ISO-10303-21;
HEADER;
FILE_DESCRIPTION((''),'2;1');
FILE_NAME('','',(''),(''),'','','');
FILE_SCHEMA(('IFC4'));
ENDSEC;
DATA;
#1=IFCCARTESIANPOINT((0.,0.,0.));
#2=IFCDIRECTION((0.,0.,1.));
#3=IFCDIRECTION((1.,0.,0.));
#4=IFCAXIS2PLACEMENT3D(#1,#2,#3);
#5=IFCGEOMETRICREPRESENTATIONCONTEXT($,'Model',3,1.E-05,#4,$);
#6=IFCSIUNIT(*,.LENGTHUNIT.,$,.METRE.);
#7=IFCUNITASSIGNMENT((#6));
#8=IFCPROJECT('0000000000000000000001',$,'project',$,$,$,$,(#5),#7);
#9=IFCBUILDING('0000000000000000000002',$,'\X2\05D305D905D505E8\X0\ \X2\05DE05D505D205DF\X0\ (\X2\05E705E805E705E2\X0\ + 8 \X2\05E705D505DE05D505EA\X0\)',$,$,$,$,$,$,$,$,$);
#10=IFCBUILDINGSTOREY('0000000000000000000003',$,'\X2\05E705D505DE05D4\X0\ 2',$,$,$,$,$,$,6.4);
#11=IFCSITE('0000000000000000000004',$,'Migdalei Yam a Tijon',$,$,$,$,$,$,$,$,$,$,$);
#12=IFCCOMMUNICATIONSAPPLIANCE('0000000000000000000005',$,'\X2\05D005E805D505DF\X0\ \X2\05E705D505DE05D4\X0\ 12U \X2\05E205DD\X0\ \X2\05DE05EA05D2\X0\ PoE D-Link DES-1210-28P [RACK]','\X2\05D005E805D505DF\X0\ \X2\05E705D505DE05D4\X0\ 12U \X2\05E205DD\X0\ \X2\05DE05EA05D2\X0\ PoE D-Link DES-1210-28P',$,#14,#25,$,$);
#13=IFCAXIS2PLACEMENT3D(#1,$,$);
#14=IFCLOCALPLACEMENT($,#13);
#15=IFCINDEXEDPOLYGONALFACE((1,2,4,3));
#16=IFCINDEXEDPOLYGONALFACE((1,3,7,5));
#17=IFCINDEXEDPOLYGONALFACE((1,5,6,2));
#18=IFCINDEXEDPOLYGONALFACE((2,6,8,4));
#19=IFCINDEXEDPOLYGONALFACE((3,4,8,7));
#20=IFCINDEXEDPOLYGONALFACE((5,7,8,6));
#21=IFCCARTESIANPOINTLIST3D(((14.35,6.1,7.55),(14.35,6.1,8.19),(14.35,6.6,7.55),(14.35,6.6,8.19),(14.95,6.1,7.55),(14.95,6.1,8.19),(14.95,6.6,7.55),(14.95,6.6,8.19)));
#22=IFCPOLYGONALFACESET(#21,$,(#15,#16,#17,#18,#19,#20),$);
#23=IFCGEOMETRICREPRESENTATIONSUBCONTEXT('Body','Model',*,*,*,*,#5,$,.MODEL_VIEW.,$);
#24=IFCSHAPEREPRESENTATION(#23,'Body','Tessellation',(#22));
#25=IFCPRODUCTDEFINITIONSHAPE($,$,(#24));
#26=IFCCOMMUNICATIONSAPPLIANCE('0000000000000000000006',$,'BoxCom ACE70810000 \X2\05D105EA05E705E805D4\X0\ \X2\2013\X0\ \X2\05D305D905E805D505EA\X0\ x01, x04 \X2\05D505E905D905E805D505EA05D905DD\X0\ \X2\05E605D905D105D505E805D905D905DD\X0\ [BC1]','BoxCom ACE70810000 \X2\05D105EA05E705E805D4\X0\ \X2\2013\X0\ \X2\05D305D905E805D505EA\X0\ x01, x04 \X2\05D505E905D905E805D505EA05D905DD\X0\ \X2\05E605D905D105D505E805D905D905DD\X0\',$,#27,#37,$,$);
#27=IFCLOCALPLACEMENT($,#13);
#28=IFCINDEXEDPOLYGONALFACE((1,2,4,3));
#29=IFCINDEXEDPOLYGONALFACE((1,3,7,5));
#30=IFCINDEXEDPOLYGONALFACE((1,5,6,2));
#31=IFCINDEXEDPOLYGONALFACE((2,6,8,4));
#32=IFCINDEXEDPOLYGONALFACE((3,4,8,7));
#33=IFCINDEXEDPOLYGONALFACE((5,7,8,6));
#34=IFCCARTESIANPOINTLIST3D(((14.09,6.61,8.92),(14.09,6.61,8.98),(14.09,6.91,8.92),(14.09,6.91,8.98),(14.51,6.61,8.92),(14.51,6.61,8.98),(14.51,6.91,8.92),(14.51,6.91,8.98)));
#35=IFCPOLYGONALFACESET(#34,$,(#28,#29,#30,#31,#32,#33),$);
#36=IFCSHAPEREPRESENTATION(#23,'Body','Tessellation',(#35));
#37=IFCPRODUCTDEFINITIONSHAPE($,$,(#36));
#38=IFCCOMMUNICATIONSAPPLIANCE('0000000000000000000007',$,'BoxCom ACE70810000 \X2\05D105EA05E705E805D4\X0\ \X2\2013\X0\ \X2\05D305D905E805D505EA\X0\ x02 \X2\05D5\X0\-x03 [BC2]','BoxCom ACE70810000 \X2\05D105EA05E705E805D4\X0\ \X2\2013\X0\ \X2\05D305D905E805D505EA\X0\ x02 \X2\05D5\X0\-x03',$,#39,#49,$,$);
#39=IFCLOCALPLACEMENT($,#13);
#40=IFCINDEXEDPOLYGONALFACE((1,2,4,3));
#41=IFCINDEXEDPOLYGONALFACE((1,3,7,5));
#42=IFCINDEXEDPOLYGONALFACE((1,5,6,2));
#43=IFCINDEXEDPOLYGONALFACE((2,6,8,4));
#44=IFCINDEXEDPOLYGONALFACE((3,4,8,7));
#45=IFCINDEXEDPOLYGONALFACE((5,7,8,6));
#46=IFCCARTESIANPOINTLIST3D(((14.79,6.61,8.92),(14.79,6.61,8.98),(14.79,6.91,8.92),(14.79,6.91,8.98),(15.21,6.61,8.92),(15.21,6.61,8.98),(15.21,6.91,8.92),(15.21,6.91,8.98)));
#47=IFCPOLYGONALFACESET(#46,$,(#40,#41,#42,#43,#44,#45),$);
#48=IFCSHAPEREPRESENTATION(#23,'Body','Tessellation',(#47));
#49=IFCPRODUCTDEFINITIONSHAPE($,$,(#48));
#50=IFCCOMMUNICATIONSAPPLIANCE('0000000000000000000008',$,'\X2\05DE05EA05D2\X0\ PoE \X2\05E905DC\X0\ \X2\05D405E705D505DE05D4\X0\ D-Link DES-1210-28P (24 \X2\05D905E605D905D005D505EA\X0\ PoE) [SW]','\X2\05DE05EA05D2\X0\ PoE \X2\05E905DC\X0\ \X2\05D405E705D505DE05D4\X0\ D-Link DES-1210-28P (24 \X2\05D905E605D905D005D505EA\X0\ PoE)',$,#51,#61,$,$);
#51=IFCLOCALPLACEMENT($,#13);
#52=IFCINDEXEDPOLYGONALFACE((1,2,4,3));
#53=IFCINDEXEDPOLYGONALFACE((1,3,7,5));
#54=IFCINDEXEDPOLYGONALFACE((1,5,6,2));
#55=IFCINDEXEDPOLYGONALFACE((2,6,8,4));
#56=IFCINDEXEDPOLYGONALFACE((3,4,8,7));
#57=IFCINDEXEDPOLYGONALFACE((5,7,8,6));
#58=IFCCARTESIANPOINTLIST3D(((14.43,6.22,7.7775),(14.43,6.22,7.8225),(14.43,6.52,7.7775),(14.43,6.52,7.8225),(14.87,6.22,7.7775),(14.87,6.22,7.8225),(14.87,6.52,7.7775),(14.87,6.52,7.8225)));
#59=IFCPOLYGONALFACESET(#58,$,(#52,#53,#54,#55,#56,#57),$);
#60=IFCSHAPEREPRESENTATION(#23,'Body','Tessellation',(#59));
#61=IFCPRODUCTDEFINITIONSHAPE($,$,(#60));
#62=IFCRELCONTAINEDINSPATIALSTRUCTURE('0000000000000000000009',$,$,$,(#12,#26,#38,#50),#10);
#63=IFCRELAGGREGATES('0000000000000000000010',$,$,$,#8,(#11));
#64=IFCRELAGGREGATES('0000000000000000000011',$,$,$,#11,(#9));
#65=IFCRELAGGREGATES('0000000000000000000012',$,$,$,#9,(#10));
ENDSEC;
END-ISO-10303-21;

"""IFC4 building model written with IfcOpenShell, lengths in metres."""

from ifc_helpers import new_model, si_unit, frame, origin_with_axes, context, subcontext, project, spatial, line, indexed_curve, outline, extrude, element, save


model = new_model("IFC4")

# Units and contexts
model_context = context("Model", 3, precision=1e-05, world=origin_with_axes())
body_context = subcontext(model_context, "Body", "Model", "MODEL_VIEW")
ifc_project = project(units=[si_unit("LENGTHUNIT", "METRE")], contexts=[model_context])

# Site, building, storey
site = spatial("IfcSite", under=ifc_project, Name="Migdalei Yam a Tijon")
building = spatial("IfcBuilding", under=site, Name="דיור מוגן (קרקע + 8 קומות)")
storey = spatial("IfcBuildingStorey", under=building, Name="קומה 2", Elevation=6.4)

# Communications appliances
element("IfcCommunicationsAppliance", 1, inside=storey, Name="ארון קומה 12U עם מתג PoE D-Link DES-1210-28P [RACK]", Description="ארון קומה 12U עם מתג PoE D-Link DES-1210-28P", context=body_context, shape_type="SweptSolid", body=[
    extrude(outline(indexed_curve([(0.0, 0.0), (0.6, 0.0), (0.6, 0.5), (0.0, 0.5)], segments=[line(1, 2, 3, 4, 1)])), frame((14.35, 6.1, 7.55), z_axis=(0.0, 0.0, 1.0), x_axis=(1.0, 0.0, 0.0)), (0.0, 0.0, 1.0), 0.64),
])
element("IfcCommunicationsAppliance", 2, inside=storey, Name="BoxCom ACE70810000 בתקרה – דירות x01, x04 ושירותים ציבוריים [BC1]", Description="BoxCom ACE70810000 בתקרה – דירות x01, x04 ושירותים ציבוריים", context=body_context, shape_type="SweptSolid", body=[
    extrude(outline(indexed_curve([(0.0, 0.0), (0.42, 0.0), (0.42, 0.3), (0.0, 0.3)], segments=[line(1, 2, 3, 4, 1)])), frame((14.09, 6.61, 8.92), z_axis=(0.0, 0.0, 1.0), x_axis=(1.0, 0.0, 0.0)), (0.0, 0.0, 1.0), 0.06),
])
element("IfcCommunicationsAppliance", 3, inside=storey, Name="BoxCom ACE70810000 בתקרה – דירות x02 ו-x03 [BC2]", Description="BoxCom ACE70810000 בתקרה – דירות x02 ו-x03", context=body_context, shape_type="SweptSolid", body=[
    extrude(outline(indexed_curve([(0.0, 0.0), (0.42, 0.0), (0.42, 0.3), (0.0, 0.3)], segments=[line(1, 2, 3, 4, 1)])), frame((14.79, 6.61, 8.92), z_axis=(0.0, 0.0, 1.0), x_axis=(1.0, 0.0, 0.0)), (0.0, 0.0, 1.0), 0.06),
])
element("IfcCommunicationsAppliance", 4, inside=storey, Name="מתג PoE של הקומה D-Link DES-1210-28P (24 יציאות PoE) [SW]", Description="מתג PoE של הקומה D-Link DES-1210-28P (24 יציאות PoE)", context=body_context, shape_type="SweptSolid", body=[
    extrude(outline(indexed_curve([(0.0, 0.0), (0.44, 0.0), (0.44, 0.3), (0.0, 0.3)], segments=[line(1, 2, 3, 4, 1)])), frame((14.43, 6.22, 7.7775), z_axis=(0.0, 0.0, 1.0), x_axis=(1.0, 0.0, 0.0)), (0.0, 0.0, 1.0), 0.045),
])

save(model, "model.ifc")
